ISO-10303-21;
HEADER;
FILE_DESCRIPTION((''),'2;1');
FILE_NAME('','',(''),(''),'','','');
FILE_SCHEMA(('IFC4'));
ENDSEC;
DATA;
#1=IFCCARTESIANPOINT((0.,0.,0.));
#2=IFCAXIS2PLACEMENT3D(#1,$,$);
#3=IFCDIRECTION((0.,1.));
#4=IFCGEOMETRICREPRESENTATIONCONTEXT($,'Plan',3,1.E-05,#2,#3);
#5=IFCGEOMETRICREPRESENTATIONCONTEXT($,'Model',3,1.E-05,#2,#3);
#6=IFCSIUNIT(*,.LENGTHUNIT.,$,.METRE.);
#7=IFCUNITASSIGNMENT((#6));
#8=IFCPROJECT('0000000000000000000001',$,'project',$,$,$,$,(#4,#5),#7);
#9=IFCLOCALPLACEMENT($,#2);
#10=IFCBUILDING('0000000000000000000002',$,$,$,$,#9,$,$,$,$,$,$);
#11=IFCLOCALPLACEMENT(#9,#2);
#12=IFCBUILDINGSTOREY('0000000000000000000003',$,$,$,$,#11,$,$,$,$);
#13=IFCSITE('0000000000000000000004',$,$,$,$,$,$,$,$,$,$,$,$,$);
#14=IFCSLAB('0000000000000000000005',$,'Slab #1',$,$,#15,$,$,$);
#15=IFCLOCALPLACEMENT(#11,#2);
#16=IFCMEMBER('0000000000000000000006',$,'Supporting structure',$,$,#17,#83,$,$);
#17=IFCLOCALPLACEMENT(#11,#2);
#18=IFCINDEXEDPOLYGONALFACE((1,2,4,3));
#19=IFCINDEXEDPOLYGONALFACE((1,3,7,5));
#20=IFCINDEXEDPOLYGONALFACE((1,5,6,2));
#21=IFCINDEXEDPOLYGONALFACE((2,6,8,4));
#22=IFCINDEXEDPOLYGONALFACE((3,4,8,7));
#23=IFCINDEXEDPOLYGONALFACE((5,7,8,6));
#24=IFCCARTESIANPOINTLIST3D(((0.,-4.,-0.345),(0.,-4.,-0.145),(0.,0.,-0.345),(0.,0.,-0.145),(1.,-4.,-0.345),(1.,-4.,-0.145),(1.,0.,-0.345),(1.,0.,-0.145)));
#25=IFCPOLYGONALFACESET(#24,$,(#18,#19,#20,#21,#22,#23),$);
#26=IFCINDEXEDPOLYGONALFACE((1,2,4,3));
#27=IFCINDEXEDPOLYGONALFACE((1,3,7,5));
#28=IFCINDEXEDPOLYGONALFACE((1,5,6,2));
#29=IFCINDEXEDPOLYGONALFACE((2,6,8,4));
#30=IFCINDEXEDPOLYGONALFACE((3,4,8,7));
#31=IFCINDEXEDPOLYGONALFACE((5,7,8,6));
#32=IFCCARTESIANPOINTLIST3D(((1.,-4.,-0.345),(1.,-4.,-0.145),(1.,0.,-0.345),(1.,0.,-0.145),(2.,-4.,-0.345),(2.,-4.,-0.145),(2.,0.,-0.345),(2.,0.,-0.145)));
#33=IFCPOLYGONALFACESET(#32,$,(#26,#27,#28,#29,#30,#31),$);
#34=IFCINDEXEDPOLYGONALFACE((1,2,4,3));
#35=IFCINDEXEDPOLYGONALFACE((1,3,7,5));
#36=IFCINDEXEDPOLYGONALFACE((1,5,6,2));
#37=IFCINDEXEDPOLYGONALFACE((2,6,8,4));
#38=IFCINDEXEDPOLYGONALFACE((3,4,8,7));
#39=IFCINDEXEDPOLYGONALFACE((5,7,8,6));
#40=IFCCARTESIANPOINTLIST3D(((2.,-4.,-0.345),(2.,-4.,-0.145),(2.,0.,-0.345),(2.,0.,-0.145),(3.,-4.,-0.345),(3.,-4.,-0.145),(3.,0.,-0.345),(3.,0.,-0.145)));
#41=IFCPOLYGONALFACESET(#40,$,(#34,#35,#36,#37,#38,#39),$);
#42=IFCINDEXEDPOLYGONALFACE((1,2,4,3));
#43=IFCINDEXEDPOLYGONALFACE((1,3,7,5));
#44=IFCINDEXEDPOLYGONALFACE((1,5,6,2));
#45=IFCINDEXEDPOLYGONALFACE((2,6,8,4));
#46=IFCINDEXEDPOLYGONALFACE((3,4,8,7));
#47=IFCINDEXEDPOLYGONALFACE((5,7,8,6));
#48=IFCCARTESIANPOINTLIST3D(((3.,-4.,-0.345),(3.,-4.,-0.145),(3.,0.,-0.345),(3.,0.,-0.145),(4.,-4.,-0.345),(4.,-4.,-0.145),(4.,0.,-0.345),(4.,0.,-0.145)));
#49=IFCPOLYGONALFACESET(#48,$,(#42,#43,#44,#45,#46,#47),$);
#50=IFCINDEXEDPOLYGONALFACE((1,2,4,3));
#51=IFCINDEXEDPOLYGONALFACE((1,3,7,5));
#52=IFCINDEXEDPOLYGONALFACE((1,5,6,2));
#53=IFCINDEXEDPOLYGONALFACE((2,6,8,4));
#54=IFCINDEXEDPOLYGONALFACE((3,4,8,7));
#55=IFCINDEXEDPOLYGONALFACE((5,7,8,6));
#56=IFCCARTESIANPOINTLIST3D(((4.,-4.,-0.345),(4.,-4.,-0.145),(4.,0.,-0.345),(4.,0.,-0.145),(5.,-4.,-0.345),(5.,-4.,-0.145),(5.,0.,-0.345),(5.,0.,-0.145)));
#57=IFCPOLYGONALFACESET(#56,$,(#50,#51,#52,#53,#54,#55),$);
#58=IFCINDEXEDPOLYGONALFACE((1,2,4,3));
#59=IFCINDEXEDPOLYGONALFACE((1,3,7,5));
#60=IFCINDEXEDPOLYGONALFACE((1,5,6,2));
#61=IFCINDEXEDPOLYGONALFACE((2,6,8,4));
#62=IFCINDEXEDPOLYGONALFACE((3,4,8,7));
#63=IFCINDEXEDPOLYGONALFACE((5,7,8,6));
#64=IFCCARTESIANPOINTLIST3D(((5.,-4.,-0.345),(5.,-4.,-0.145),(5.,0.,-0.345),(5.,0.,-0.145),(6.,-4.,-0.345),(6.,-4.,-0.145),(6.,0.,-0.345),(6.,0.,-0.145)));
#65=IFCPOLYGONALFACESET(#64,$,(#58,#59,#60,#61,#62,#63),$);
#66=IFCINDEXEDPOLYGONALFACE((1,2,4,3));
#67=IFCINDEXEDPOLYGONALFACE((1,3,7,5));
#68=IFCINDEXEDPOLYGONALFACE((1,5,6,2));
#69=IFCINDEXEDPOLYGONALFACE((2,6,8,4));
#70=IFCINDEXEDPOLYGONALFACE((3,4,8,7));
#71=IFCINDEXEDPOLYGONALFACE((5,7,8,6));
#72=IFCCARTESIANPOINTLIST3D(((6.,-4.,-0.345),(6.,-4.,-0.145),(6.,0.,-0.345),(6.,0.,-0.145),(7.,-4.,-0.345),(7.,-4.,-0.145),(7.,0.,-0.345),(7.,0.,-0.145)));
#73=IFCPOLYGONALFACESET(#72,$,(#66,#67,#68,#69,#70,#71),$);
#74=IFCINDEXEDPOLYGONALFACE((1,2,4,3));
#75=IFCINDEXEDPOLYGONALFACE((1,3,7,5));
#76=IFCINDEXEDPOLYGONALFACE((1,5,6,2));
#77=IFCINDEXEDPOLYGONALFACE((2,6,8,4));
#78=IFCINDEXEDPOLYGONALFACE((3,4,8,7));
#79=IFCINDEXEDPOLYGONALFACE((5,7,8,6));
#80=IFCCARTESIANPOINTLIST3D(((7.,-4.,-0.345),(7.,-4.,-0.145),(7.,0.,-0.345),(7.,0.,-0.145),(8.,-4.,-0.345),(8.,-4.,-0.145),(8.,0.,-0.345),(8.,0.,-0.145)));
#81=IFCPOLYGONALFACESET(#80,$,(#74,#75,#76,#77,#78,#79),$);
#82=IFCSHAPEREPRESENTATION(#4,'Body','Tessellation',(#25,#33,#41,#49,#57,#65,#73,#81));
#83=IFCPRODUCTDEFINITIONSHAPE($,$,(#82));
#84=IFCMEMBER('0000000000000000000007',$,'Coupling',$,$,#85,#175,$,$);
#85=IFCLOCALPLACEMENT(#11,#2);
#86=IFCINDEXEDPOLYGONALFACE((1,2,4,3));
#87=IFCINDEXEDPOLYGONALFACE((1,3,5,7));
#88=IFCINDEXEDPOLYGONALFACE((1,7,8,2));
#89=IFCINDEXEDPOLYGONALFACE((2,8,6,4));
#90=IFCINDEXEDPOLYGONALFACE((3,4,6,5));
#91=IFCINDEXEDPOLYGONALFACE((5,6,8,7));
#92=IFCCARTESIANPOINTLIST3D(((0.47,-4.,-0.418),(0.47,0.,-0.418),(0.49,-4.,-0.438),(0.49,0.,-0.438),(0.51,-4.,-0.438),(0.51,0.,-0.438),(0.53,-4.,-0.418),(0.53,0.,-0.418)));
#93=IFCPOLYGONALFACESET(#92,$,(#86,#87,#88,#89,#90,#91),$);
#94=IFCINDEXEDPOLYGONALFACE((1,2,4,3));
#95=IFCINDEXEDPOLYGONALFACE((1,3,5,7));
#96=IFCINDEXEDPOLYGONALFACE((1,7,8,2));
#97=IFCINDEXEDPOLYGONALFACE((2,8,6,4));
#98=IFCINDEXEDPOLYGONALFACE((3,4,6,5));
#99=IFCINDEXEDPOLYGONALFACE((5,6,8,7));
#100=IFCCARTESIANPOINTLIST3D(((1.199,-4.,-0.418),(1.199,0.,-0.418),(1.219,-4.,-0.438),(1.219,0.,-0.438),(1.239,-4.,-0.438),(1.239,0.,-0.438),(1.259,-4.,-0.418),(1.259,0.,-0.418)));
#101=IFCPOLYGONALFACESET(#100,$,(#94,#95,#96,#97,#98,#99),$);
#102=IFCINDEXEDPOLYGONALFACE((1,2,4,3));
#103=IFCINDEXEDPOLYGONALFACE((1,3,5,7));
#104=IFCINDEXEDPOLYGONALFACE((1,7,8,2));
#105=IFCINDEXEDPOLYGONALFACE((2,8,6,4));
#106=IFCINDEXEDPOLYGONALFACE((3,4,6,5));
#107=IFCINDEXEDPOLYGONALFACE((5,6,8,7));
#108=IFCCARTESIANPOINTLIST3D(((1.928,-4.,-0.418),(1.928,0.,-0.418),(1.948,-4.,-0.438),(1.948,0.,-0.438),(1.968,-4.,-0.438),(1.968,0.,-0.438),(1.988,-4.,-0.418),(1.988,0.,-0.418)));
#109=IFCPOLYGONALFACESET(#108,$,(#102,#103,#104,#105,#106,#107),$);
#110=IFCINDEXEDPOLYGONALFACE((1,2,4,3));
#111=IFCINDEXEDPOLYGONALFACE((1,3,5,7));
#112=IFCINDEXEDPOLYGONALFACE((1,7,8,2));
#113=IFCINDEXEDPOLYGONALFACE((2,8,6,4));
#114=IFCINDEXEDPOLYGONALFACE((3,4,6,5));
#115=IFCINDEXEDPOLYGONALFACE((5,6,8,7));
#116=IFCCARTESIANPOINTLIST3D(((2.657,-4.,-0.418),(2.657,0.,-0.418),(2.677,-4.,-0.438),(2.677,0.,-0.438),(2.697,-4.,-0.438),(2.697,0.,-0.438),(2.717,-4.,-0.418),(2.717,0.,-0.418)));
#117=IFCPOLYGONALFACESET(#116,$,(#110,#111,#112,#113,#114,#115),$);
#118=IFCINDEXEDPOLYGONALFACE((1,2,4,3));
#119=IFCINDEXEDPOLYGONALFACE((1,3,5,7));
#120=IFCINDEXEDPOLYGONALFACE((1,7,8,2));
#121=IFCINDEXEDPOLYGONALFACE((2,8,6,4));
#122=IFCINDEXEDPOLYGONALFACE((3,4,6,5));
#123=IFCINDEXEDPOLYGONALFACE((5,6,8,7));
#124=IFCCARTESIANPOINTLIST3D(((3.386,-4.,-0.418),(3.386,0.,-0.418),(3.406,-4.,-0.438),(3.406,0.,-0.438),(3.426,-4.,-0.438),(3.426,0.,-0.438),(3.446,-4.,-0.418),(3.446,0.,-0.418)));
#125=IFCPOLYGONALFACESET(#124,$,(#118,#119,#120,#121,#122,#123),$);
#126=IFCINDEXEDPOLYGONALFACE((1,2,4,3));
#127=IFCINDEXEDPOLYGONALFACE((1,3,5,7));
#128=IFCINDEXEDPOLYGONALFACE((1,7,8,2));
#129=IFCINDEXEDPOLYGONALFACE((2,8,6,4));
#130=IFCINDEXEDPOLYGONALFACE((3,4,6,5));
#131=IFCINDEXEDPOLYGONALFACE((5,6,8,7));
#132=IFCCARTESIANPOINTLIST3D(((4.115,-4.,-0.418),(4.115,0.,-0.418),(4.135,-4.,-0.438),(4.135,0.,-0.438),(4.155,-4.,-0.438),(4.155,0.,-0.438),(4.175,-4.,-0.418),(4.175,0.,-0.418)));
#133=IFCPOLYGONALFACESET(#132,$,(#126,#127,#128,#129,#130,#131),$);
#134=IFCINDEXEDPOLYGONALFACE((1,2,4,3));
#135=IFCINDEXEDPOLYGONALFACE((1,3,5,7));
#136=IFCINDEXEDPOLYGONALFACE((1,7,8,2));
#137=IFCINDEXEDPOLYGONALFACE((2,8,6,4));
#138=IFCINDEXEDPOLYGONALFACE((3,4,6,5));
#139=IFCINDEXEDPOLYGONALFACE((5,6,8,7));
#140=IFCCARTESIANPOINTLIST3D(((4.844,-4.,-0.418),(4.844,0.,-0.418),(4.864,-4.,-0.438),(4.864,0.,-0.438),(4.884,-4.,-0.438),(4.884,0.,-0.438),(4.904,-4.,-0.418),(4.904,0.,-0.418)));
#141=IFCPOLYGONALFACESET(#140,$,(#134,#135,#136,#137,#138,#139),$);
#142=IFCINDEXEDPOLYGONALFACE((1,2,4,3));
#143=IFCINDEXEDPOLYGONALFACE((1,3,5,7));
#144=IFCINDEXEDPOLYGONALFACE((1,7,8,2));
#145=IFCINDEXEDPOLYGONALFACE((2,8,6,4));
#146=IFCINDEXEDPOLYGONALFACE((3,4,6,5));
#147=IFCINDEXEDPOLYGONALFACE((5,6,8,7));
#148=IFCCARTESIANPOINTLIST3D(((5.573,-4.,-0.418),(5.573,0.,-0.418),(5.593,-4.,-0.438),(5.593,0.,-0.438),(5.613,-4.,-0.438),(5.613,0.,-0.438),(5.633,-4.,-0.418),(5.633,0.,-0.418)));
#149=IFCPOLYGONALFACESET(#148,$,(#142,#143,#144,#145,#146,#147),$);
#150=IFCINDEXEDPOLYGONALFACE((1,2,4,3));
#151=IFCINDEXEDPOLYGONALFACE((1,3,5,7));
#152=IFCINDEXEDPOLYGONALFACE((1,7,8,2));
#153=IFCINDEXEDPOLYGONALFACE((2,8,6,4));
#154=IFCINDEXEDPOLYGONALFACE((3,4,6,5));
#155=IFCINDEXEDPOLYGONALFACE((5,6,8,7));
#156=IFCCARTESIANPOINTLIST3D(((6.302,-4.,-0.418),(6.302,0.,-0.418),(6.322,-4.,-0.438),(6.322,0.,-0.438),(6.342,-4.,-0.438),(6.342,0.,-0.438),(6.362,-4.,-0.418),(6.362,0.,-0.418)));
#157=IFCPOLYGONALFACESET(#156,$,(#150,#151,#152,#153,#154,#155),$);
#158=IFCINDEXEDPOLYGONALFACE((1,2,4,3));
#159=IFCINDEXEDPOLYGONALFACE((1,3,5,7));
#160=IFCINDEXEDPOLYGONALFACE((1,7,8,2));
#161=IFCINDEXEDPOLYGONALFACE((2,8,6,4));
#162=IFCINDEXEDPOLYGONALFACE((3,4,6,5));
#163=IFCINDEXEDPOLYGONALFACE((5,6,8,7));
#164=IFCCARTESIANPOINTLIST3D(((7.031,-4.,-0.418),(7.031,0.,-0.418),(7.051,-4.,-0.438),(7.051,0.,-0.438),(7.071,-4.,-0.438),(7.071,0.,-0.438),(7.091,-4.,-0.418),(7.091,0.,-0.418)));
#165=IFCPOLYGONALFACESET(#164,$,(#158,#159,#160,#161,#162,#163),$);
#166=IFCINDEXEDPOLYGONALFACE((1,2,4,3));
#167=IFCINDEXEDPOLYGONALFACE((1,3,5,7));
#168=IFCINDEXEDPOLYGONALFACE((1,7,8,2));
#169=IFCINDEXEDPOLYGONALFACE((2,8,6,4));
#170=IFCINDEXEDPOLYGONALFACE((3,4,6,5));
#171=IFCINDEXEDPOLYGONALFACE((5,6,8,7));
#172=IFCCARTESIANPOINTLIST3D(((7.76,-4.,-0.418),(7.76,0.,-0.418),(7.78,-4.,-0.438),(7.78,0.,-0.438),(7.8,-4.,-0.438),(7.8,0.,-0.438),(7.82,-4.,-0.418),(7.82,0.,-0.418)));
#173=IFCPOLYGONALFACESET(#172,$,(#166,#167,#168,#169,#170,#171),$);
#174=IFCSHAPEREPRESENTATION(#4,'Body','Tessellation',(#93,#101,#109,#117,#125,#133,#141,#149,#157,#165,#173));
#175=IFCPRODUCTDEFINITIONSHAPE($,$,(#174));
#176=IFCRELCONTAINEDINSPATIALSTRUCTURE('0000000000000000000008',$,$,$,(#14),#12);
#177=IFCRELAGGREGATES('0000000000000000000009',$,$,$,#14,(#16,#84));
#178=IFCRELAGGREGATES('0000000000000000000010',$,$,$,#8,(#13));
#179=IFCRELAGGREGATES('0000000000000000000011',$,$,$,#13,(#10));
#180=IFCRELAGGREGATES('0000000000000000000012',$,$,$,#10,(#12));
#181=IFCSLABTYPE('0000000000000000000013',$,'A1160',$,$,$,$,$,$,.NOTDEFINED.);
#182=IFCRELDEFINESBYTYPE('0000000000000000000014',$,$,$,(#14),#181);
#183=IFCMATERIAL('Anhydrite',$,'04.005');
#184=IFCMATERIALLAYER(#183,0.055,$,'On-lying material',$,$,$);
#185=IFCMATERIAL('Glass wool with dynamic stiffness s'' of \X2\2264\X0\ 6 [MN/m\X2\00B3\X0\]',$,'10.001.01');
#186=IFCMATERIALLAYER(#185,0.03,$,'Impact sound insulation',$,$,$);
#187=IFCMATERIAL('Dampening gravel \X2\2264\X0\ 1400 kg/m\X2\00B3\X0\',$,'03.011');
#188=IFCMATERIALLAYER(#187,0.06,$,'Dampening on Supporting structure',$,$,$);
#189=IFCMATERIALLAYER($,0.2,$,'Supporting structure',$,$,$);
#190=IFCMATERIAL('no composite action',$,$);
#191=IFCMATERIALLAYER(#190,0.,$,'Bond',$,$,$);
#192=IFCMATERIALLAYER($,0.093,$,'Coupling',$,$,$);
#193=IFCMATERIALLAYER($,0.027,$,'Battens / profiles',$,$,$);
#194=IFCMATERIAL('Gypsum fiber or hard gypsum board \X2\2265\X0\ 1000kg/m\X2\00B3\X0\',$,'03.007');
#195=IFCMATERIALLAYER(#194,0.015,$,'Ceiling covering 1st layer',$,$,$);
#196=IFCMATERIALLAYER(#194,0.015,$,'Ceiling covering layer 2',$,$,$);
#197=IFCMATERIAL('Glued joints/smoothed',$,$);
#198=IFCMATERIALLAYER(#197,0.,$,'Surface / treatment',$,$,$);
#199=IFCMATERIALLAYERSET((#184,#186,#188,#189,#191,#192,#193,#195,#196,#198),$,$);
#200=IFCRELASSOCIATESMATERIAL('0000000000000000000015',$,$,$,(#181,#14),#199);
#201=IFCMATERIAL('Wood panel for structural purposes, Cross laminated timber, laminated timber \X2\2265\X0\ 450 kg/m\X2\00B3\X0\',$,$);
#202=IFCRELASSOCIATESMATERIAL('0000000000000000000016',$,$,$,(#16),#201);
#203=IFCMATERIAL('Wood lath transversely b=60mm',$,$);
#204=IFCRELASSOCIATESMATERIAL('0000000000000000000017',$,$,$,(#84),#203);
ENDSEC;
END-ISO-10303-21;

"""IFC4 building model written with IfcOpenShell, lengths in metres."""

from ifc_helpers import new_model, si_unit, direction, frame, frame_2d, origin, place, context, project, spatial, polyline, rectangle, outline, extrude, material, layer, layer_set, type_object, element, aggregate, save


model = new_model("IFC4")

# Units and contexts
plan_context = context("Plan", 3, precision=1e-05, world=origin(), true_north=direction((0.0, 1.0)))
model_context = context("Model", 3, precision=1e-05, world=origin(), true_north=direction((0.0, 1.0)))
ifc_project = project(units=[si_unit("LENGTHUNIT", "METRE")], contexts=[plan_context, model_context])

# Site, building, storey
site = spatial("IfcSite", under=ifc_project)
building_placement = place(None, origin())
building = spatial("IfcBuilding", under=site, at=building_placement)
storey_placement = place(building_placement, origin())
storey = spatial("IfcBuildingStorey", under=building, at=storey_placement)

# Slab, members
ifc_material_1 = material(Name="Anhydrite", Category="04.005")
ifc_layer_1 = layer(ifc_material_1, 0.055, Name="On-lying material")
ifc_material_2 = material(Name="Glass wool with dynamic stiffness s' of ≤ 6 [MN/m³]", Category="10.001.01")
ifc_layer_2 = layer(ifc_material_2, 0.03, Name="Impact sound insulation")
ifc_material_3 = material(Name="Dampening gravel ≤ 1400 kg/m³", Category="03.011")
ifc_layer_3 = layer(ifc_material_3, 0.06, Name="Dampening on Supporting structure")
ifc_layer_4 = layer(None, 0.2, Name="Supporting structure")
ifc_material_4 = material(Name="no composite action")
ifc_layer_5 = layer(ifc_material_4, 0.0, Name="Bond")
ifc_layer_6 = layer(None, 0.093, Name="Coupling")
ifc_layer_7 = layer(None, 0.027, Name="Battens / profiles")
ifc_material_5 = material(Name="Gypsum fiber or hard gypsum board ≥ 1000kg/m³", Category="03.007")
ifc_layer_8 = layer(ifc_material_5, 0.015, Name="Ceiling covering 1st layer")
ifc_layer_9 = layer(ifc_material_5, 0.015, Name="Ceiling covering layer 2")
ifc_material_6 = material(Name="Glued joints/smoothed")
ifc_layer_10 = layer(ifc_material_6, 0.0, Name="Surface / treatment")
ifc_layer_set = layer_set([ifc_layer_1, ifc_layer_2, ifc_layer_3, ifc_layer_4, ifc_layer_5, ifc_layer_6, ifc_layer_7, ifc_layer_8, ifc_layer_9, ifc_layer_10])
slab_type = type_object("IfcSlabType", Name="A1160", PredefinedType="NOTDEFINED", material=ifc_layer_set)
slab_placement = place(None, frame((0.0, 0.0, 0.0), z_axis=(0.0, 0.0, -1.0), x_axis=(1.0, 0.0, 0.0)))
slab = element("IfcSlab", 1, at=slab_placement, inside=storey, type_object=slab_type, material=ifc_layer_set, Name="Slab #1")
ifc_material_7 = material(Name="Wood panel for structural purposes, Cross laminated timber, laminated timber ≥ 450 kg/m³")
member_1_placement = place(slab_placement, origin())
member_1 = element("IfcMember", 2, at=member_1_placement, material=ifc_material_7, Name="Supporting structure", context=plan_context, shape_type="SweptSolid", body=[
    extrude(rectangle(XDim=1.0, YDim=0.2, at=frame_2d((0.5, 0.1), x_axis=(1.0, 0.0))), frame((0.0, 4.0, 0.145), z_axis=(0.0, -1.0, 0.0), x_axis=(1.0, 0.0, 0.0)), (0.0, 0.0, 1.0), 4.0),
    extrude(rectangle(XDim=1.0, YDim=0.2, at=frame_2d((0.5, 0.1), x_axis=(1.0, 0.0))), frame((1.0, 4.0, 0.145), z_axis=(0.0, -1.0, 0.0), x_axis=(1.0, 0.0, 0.0)), (0.0, 0.0, 1.0), 4.0),
    extrude(rectangle(XDim=1.0, YDim=0.2, at=frame_2d((0.5, 0.1), x_axis=(1.0, 0.0))), frame((2.0, 4.0, 0.145), z_axis=(0.0, -1.0, 0.0), x_axis=(1.0, 0.0, 0.0)), (0.0, 0.0, 1.0), 4.0),
    extrude(rectangle(XDim=1.0, YDim=0.2, at=frame_2d((0.5, 0.1), x_axis=(1.0, 0.0))), frame((3.0, 4.0, 0.145), z_axis=(0.0, -1.0, 0.0), x_axis=(1.0, 0.0, 0.0)), (0.0, 0.0, 1.0), 4.0),
    extrude(rectangle(XDim=1.0, YDim=0.2, at=frame_2d((0.5, 0.1), x_axis=(1.0, 0.0))), frame((4.0, 4.0, 0.145), z_axis=(0.0, -1.0, 0.0), x_axis=(1.0, 0.0, 0.0)), (0.0, 0.0, 1.0), 4.0),
    extrude(rectangle(XDim=1.0, YDim=0.2, at=frame_2d((0.5, 0.1), x_axis=(1.0, 0.0))), frame((5.0, 4.0, 0.145), z_axis=(0.0, -1.0, 0.0), x_axis=(1.0, 0.0, 0.0)), (0.0, 0.0, 1.0), 4.0),
    extrude(rectangle(XDim=1.0, YDim=0.2, at=frame_2d((0.5, 0.1), x_axis=(1.0, 0.0))), frame((6.0, 4.0, 0.145), z_axis=(0.0, -1.0, 0.0), x_axis=(1.0, 0.0, 0.0)), (0.0, 0.0, 1.0), 4.0),
    extrude(rectangle(XDim=1.0, YDim=0.2, at=frame_2d((0.5, 0.1), x_axis=(1.0, 0.0))), frame((7.0, 4.0, 0.145), z_axis=(0.0, -1.0, 0.0), x_axis=(1.0, 0.0, 0.0)), (0.0, 0.0, 1.0), 4.0),
])
ifc_material_8 = material(Name="Wood lath transversely b=60mm")
member_2_placement = place(slab_placement, origin())
member_2 = element("IfcMember", 3, at=member_2_placement, material=ifc_material_8, Name="Coupling", context=plan_context, shape_type="SweptSolid", body=[
    extrude(outline(polyline([(0.0, 0.0), (0.06, 0.0), (0.04, 0.02), (0.02, 0.02), (0.0, 0.0)])), frame((0.47, 4.0, 0.418), z_axis=(0.0, -1.0, 0.0), x_axis=(1.0, 0.0, 0.0)), (0.0, 0.0, 1.0), 4.0),
    extrude(outline(polyline([(0.0, 0.0), (0.06, 0.0), (0.04, 0.02), (0.02, 0.02), (0.0, 0.0)])), frame((1.199, 4.0, 0.418), z_axis=(0.0, -1.0, 0.0), x_axis=(1.0, 0.0, 0.0)), (0.0, 0.0, 1.0), 4.0),
    extrude(outline(polyline([(0.0, 0.0), (0.06, 0.0), (0.04, 0.02), (0.02, 0.02), (0.0, 0.0)])), frame((1.928, 4.0, 0.418), z_axis=(0.0, -1.0, 0.0), x_axis=(1.0, 0.0, 0.0)), (0.0, 0.0, 1.0), 4.0),
    extrude(outline(polyline([(0.0, 0.0), (0.06, 0.0), (0.04, 0.02), (0.02, 0.02), (0.0, 0.0)])), frame((2.657, 4.0, 0.418), z_axis=(0.0, -1.0, 0.0), x_axis=(1.0, 0.0, 0.0)), (0.0, 0.0, 1.0), 4.0),
    extrude(outline(polyline([(0.0, 0.0), (0.06, 0.0), (0.04, 0.02), (0.02, 0.02), (0.0, 0.0)])), frame((3.386, 4.0, 0.418), z_axis=(0.0, -1.0, 0.0), x_axis=(1.0, 0.0, 0.0)), (0.0, 0.0, 1.0), 4.0),
    extrude(outline(polyline([(0.0, 0.0), (0.06, 0.0), (0.04, 0.02), (0.02, 0.02), (0.0, 0.0)])), frame((4.115, 4.0, 0.418), z_axis=(0.0, -1.0, 0.0), x_axis=(1.0, 0.0, 0.0)), (0.0, 0.0, 1.0), 4.0),
    extrude(outline(polyline([(0.0, 0.0), (0.06, 0.0), (0.04, 0.02), (0.02, 0.02), (0.0, 0.0)])), frame((4.844, 4.0, 0.418), z_axis=(0.0, -1.0, 0.0), x_axis=(1.0, 0.0, 0.0)), (0.0, 0.0, 1.0), 4.0),
    extrude(outline(polyline([(0.0, 0.0), (0.06, 0.0), (0.04, 0.02), (0.02, 0.02), (0.0, 0.0)])), frame((5.573, 4.0, 0.418), z_axis=(0.0, -1.0, 0.0), x_axis=(1.0, 0.0, 0.0)), (0.0, 0.0, 1.0), 4.0),
    extrude(outline(polyline([(0.0, 0.0), (0.06, 0.0), (0.04, 0.02), (0.02, 0.02), (0.0, 0.0)])), frame((6.302, 4.0, 0.418), z_axis=(0.0, -1.0, 0.0), x_axis=(1.0, 0.0, 0.0)), (0.0, 0.0, 1.0), 4.0),
    extrude(outline(polyline([(0.0, 0.0), (0.06, 0.0), (0.04, 0.02), (0.02, 0.02), (0.0, 0.0)])), frame((7.031, 4.0, 0.418), z_axis=(0.0, -1.0, 0.0), x_axis=(1.0, 0.0, 0.0)), (0.0, 0.0, 1.0), 4.0),
    extrude(outline(polyline([(0.0, 0.0), (0.06, 0.0), (0.04, 0.02), (0.02, 0.02), (0.0, 0.0)])), frame((7.76, 4.0, 0.418), z_axis=(0.0, -1.0, 0.0), x_axis=(1.0, 0.0, 0.0)), (0.0, 0.0, 1.0), 4.0),
])
aggregate(slab, [member_1, member_2])

save(model, "model.ifc")
